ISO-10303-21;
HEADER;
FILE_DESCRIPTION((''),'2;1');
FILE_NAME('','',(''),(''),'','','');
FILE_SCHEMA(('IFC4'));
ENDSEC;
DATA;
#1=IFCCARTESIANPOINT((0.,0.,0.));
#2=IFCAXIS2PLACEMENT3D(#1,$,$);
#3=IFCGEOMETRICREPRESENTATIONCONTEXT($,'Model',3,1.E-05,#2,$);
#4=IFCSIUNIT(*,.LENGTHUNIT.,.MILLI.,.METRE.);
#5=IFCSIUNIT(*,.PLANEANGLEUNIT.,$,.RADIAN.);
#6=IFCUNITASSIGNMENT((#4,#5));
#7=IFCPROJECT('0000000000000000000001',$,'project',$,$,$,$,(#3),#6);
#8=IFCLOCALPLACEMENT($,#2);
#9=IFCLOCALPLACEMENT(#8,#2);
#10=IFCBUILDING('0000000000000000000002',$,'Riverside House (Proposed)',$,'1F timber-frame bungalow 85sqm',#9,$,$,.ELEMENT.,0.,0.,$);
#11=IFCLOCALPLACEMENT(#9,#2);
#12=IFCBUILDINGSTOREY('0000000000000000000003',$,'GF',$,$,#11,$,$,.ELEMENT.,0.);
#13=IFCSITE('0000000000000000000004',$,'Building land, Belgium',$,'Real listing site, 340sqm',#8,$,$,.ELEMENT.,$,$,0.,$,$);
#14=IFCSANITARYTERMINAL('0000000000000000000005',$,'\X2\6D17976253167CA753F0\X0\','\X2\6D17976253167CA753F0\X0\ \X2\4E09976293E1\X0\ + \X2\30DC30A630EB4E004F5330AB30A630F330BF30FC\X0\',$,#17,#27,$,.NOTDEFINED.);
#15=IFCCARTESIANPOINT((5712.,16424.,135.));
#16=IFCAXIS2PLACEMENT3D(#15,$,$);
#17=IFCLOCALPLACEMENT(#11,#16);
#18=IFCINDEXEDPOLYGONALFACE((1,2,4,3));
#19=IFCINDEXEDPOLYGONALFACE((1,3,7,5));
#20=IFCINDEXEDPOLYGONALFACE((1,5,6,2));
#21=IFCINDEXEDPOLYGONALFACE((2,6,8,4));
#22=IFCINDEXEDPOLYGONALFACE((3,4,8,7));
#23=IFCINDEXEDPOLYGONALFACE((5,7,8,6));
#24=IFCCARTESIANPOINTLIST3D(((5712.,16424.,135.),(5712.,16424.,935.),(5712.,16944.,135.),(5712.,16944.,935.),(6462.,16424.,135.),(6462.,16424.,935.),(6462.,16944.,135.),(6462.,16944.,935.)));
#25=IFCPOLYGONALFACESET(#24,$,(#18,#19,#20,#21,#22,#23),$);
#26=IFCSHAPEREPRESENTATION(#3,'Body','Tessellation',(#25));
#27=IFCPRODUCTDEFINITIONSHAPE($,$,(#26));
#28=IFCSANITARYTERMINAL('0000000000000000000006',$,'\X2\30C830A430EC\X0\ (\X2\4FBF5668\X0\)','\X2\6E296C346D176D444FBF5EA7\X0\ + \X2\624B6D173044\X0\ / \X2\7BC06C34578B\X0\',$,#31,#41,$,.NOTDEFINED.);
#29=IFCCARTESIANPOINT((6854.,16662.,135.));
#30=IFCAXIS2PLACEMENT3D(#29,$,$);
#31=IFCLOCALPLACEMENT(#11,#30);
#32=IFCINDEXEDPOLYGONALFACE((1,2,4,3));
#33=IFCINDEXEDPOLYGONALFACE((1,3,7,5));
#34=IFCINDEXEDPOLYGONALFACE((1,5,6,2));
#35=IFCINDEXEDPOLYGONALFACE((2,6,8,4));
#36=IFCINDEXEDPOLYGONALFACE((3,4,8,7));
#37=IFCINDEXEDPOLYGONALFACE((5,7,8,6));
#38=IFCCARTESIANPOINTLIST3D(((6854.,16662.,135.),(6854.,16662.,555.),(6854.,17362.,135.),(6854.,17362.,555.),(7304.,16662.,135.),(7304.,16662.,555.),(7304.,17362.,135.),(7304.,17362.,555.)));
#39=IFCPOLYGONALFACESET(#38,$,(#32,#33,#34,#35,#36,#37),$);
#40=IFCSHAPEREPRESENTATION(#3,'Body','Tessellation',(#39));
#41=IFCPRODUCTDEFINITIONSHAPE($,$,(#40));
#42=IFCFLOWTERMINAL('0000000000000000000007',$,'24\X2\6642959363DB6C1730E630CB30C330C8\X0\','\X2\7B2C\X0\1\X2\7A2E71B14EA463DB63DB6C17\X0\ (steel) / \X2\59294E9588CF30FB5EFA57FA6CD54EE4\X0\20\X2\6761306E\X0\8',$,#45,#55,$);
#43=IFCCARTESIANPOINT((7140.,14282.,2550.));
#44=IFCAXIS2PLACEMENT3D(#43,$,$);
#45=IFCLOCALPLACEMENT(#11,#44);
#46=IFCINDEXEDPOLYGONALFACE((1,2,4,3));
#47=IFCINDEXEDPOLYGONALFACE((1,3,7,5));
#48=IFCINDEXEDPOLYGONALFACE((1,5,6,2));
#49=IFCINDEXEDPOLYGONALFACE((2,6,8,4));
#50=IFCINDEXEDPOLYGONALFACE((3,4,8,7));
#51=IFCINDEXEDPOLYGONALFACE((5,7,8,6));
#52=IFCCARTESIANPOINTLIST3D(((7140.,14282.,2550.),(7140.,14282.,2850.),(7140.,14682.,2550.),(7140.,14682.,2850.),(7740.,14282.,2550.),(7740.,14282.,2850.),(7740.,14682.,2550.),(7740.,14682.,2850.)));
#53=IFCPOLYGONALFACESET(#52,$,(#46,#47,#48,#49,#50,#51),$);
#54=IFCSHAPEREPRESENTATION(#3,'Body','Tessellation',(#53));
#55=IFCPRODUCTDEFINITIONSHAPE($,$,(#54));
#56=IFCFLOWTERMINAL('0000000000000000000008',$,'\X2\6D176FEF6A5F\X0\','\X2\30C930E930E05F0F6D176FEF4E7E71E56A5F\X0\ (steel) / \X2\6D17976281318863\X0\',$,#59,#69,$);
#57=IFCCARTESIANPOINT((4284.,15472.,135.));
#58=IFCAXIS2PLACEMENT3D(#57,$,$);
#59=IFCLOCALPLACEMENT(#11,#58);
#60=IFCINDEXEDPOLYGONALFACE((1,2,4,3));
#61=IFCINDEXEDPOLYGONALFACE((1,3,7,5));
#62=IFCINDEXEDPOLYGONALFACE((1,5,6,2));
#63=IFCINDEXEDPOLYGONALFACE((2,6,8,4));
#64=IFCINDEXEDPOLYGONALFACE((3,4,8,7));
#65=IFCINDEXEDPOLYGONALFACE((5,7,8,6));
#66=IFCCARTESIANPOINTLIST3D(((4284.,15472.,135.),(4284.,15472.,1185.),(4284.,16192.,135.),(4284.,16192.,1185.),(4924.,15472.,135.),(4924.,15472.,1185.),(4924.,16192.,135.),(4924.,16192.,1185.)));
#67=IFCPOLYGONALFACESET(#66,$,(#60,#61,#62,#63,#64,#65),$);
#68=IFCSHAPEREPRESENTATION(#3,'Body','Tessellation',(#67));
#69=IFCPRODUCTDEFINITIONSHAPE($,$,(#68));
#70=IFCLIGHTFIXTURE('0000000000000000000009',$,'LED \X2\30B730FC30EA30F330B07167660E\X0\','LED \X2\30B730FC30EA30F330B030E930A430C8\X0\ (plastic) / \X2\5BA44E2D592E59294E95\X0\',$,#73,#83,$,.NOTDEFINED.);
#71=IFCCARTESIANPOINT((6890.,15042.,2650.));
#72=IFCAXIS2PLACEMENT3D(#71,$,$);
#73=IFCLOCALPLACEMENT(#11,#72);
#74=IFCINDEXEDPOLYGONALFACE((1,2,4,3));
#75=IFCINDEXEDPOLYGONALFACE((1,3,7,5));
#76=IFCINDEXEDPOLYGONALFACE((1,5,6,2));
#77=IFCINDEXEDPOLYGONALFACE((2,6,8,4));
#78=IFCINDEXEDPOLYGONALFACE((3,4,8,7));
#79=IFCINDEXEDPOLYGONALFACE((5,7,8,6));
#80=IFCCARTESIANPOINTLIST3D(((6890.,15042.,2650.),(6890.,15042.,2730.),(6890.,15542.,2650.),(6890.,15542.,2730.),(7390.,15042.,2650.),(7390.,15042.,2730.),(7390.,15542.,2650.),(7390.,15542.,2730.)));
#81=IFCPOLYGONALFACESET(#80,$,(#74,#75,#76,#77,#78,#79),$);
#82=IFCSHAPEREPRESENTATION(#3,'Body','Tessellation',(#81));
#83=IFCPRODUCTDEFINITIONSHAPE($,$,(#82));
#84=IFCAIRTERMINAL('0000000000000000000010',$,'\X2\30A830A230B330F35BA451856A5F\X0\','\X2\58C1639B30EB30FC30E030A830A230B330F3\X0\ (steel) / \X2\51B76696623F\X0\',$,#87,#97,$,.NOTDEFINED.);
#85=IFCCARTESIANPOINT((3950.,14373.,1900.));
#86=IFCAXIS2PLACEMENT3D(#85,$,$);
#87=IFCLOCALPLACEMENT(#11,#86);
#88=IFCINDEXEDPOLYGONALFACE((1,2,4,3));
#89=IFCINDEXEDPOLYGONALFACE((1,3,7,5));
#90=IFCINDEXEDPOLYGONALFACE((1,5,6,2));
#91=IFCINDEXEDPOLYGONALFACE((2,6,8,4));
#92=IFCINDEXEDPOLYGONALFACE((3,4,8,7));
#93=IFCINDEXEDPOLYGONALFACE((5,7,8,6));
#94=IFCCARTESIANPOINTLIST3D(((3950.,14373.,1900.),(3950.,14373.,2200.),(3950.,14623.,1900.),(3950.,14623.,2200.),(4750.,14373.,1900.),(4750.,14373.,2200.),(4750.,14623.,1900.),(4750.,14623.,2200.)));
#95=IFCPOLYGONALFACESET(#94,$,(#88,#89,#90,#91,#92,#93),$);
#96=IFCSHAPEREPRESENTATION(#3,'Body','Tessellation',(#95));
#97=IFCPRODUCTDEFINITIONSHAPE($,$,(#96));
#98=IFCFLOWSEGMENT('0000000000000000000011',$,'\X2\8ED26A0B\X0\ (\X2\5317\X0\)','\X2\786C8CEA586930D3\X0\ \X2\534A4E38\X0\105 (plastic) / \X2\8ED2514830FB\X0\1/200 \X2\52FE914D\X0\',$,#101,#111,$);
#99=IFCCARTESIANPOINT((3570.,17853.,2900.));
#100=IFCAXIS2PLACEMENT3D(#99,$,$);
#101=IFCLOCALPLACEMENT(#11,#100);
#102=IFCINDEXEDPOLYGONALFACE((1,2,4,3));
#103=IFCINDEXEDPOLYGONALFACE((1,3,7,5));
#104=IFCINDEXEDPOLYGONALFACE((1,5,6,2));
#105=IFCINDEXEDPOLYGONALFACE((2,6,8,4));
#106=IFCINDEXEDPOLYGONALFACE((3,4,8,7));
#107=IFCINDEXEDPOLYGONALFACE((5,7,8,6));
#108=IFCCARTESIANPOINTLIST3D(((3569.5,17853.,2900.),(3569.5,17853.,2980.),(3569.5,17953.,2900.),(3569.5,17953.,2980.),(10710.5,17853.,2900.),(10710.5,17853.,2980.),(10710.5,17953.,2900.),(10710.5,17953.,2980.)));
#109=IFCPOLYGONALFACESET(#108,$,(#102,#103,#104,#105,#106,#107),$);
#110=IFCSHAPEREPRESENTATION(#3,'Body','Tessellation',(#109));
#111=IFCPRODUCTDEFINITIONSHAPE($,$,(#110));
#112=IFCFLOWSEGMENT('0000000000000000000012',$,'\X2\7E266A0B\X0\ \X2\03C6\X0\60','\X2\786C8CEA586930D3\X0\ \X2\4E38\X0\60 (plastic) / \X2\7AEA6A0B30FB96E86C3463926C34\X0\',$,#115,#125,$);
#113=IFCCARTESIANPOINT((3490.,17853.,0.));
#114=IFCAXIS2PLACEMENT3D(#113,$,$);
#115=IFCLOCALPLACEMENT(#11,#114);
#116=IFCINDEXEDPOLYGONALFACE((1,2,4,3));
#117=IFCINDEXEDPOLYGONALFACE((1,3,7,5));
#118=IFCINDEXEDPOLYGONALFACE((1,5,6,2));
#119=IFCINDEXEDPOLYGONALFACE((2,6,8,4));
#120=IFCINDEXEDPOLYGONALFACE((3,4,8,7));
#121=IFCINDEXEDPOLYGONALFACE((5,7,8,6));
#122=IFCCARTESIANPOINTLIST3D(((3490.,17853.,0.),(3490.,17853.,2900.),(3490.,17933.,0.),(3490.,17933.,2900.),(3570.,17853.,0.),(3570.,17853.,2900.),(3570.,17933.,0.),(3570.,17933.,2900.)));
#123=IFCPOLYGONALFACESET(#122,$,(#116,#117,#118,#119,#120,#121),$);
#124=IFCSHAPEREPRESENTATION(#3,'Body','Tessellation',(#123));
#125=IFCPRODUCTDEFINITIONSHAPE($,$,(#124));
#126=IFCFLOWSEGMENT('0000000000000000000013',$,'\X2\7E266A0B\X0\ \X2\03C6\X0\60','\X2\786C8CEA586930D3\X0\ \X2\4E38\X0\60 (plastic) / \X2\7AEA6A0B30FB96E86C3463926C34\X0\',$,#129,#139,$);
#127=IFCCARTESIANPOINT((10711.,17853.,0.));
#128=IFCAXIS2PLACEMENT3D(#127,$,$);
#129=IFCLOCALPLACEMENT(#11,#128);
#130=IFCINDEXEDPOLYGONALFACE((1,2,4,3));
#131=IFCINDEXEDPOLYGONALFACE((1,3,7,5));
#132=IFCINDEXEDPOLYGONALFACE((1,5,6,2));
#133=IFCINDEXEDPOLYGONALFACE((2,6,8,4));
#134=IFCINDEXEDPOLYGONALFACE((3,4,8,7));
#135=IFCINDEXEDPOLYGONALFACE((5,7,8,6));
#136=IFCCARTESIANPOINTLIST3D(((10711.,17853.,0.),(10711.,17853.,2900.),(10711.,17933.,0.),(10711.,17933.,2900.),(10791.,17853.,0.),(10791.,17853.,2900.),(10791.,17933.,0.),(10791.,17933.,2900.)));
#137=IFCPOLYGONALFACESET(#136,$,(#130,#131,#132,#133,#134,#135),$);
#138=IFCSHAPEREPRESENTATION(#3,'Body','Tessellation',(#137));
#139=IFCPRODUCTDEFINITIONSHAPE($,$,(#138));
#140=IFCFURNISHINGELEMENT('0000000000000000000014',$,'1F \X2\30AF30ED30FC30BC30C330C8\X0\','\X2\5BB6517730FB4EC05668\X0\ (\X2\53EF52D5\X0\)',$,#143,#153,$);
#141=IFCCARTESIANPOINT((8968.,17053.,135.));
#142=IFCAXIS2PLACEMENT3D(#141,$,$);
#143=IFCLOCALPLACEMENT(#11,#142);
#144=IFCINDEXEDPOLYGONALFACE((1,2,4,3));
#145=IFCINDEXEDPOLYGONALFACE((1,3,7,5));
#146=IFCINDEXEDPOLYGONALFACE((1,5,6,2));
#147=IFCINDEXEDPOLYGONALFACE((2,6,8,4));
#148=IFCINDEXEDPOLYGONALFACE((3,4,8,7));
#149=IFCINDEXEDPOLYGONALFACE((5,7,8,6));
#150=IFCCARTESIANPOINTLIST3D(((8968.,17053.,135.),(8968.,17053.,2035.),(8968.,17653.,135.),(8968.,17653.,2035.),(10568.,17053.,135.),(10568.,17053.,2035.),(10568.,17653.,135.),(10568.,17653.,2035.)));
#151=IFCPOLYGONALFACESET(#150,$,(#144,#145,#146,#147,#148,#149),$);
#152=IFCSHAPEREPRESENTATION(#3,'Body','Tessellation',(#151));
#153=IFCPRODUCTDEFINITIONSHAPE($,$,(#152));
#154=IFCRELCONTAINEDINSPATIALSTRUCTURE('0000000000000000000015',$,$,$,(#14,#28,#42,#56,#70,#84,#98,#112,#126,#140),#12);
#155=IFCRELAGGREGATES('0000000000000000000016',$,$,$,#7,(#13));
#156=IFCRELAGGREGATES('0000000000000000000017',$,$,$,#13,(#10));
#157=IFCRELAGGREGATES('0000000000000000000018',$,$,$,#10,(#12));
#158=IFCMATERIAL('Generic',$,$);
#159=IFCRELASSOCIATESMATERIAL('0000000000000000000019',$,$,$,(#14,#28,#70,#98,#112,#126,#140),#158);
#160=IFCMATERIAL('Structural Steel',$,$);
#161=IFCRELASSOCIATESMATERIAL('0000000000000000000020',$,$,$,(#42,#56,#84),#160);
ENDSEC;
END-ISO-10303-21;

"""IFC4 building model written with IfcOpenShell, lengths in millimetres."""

from ifc_helpers import new_model, si_unit, frame, frame_2d, origin, place, context, project, spatial, rectangle, extrude, material, element, save


model = new_model("IFC4")

# Units and contexts
model_context = context("Model", 3, precision=1e-05, world=origin())
ifc_project = project(units=[si_unit("LENGTHUNIT", "METRE", prefix="MILLI"), si_unit("PLANEANGLEUNIT", "RADIAN")], contexts=[model_context])

# Site, building, storey
site_placement = place(None, origin())
site = spatial("IfcSite", under=ifc_project, at=site_placement, Name="Building land, Belgium", ObjectType="Real listing site, 340sqm", CompositionType="ELEMENT", RefElevation=0.0)
building_placement = place(site_placement, origin())
building = spatial("IfcBuilding", under=site, at=building_placement, Name="Riverside House (Proposed)", ObjectType="1F timber-frame bungalow 85sqm", CompositionType="ELEMENT", ElevationOfRefHeight=0.0, ElevationOfTerrain=0.0)
storey_placement = place(building_placement, origin())
storey = spatial("IfcBuildingStorey", under=building, at=storey_placement, Name="GF", CompositionType="ELEMENT", Elevation=0.0)

# Shared definitions
ifc_material_1 = material(Name="Generic")

# Sanitary terminals
sanitary_terminal_1_placement = place(storey_placement, frame((5712.0, 16424.0, 135.0)))
element("IfcSanitaryTerminal", 1, at=sanitary_terminal_1_placement, inside=storey, material=ifc_material_1, Name="洗面化粧台", Description="洗面化粧台 三面鏡 + ボウル一体カウンター", PredefinedType="NOTDEFINED", context=model_context, shape_type="SweptSolid", body=[
    extrude(rectangle(XDim=750.0, YDim=520.0, at=frame_2d((375.0, 260.0))), frame((5712.0, 16424.0, 135.0)), (0.0, 0.0, 1.0), 800.0),
])
sanitary_terminal_2_placement = place(storey_placement, frame((6854.0, 16662.0, 135.0)))
element("IfcSanitaryTerminal", 2, at=sanitary_terminal_2_placement, inside=storey, material=ifc_material_1, Name="トイレ (便器)", Description="温水洗浄便座 + 手洗い / 節水型", PredefinedType="NOTDEFINED", context=model_context, shape_type="SweptSolid", body=[
    extrude(rectangle(XDim=450.0, YDim=700.0, at=frame_2d((225.0, 350.0))), frame((6854.0, 16662.0, 135.0)), (0.0, 0.0, 1.0), 420.0),
])

# Flow terminals
ifc_material_2 = material(Name="Structural Steel")
flow_terminal_1_placement = place(storey_placement, frame((7140.0, 14282.0, 2550.0)))
element("IfcFlowTerminal", 3, at=flow_terminal_1_placement, inside=storey, material=ifc_material_2, Name="24時間換気ユニット", Description="第1種熱交換換気 (steel) / 天井裏・建基法令20条の8", context=model_context, shape_type="SweptSolid", body=[
    extrude(rectangle(XDim=600.0, YDim=400.0, at=frame_2d((300.0, 200.0))), frame((7140.0, 14282.0, 2550.0)), (0.0, 0.0, 1.0), 300.0),
])
flow_terminal_2_placement = place(storey_placement, frame((4284.0, 15472.0, 135.0)))
element("IfcFlowTerminal", 4, at=flow_terminal_2_placement, inside=storey, material=ifc_material_2, Name="洗濯機", Description="ドラム式洗濯乾燥機 (steel) / 洗面脱衣", context=model_context, shape_type="SweptSolid", body=[
    extrude(rectangle(XDim=640.0, YDim=720.0, at=frame_2d((320.0, 360.0))), frame((4284.0, 15472.0, 135.0)), (0.0, 0.0, 1.0), 1050.0),
])

# Light fixture
light_fixture_placement = place(storey_placement, frame((6890.0, 15042.0, 2650.0)))
element("IfcLightFixture", 5, at=light_fixture_placement, inside=storey, material=ifc_material_1, Name="LED シーリング照明", Description="LED シーリングライト (plastic) / 室中央天井", PredefinedType="NOTDEFINED", context=model_context, shape_type="SweptSolid", body=[
    extrude(rectangle(XDim=500.0, YDim=500.0, at=frame_2d((250.0, 250.0))), frame((6890.0, 15042.0, 2650.0)), (0.0, 0.0, 1.0), 80.0),
])

# Air terminal
air_terminal_placement = place(storey_placement, frame((3950.0, 14373.0, 1900.0)))
element("IfcAirTerminal", 6, at=air_terminal_placement, inside=storey, material=ifc_material_2, Name="エアコン室内機", Description="壁掛ルームエアコン (steel) / 冷暖房", PredefinedType="NOTDEFINED", context=model_context, shape_type="SweptSolid", body=[
    extrude(rectangle(XDim=800.0, YDim=250.0, at=frame_2d((400.0, 125.0))), frame((3950.0, 14373.0, 1900.0)), (0.0, 0.0, 1.0), 300.0),
])

# Flow segments
flow_segment_1_placement = place(storey_placement, frame((3570.0, 17853.0, 2900.0)))
element("IfcFlowSegment", 7, at=flow_segment_1_placement, inside=storey, material=ifc_material_1, Name="軒樋 (北)", Description="硬質塩ビ 半丸105 (plastic) / 軒先・1/200 勾配", context=model_context, shape_type="SweptSolid", body=[
    extrude(rectangle(XDim=7141.0, YDim=100.0, at=frame_2d((3570.0, 50.0))), frame((3570.0, 17853.0, 2900.0)), (0.0, 0.0, 1.0), 80.0),
])
flow_segment_2_placement = place(storey_placement, frame((3490.0, 17853.0, 0.0)))
element("IfcFlowSegment", 8, at=flow_segment_2_placement, inside=storey, material=ifc_material_1, Name="縦樋 φ60", Description="硬質塩ビ 丸60 (plastic) / 竪樋・雨水排水", context=model_context, shape_type="SweptSolid", body=[
    extrude(rectangle(XDim=80.0, YDim=80.0, at=frame_2d((40.0, 40.0))), frame((3490.0, 17853.0, 0.0)), (0.0, 0.0, 1.0), 2900.0),
])
flow_segment_3_placement = place(storey_placement, frame((10711.0, 17853.0, 0.0)))
element("IfcFlowSegment", 9, at=flow_segment_3_placement, inside=storey, material=ifc_material_1, Name="縦樋 φ60", Description="硬質塩ビ 丸60 (plastic) / 竪樋・雨水排水", context=model_context, shape_type="SweptSolid", body=[
    extrude(rectangle(XDim=80.0, YDim=80.0, at=frame_2d((40.0, 40.0))), frame((10711.0, 17853.0, 0.0)), (0.0, 0.0, 1.0), 2900.0),
])

# Furnishing element
furnishing_placement = place(storey_placement, frame((8968.0, 17053.0, 135.0)))
element("IfcFurnishingElement", 10, at=furnishing_placement, inside=storey, material=ifc_material_1, Name="1F クローゼット", Description="家具・什器 (可動)", context=model_context, shape_type="SweptSolid", body=[
    extrude(rectangle(XDim=1600.0, YDim=600.0, at=frame_2d((800.0, 300.0))), frame((8968.0, 17053.0, 135.0)), (0.0, 0.0, 1.0), 1900.0),
])

save(model, "model.ifc")
